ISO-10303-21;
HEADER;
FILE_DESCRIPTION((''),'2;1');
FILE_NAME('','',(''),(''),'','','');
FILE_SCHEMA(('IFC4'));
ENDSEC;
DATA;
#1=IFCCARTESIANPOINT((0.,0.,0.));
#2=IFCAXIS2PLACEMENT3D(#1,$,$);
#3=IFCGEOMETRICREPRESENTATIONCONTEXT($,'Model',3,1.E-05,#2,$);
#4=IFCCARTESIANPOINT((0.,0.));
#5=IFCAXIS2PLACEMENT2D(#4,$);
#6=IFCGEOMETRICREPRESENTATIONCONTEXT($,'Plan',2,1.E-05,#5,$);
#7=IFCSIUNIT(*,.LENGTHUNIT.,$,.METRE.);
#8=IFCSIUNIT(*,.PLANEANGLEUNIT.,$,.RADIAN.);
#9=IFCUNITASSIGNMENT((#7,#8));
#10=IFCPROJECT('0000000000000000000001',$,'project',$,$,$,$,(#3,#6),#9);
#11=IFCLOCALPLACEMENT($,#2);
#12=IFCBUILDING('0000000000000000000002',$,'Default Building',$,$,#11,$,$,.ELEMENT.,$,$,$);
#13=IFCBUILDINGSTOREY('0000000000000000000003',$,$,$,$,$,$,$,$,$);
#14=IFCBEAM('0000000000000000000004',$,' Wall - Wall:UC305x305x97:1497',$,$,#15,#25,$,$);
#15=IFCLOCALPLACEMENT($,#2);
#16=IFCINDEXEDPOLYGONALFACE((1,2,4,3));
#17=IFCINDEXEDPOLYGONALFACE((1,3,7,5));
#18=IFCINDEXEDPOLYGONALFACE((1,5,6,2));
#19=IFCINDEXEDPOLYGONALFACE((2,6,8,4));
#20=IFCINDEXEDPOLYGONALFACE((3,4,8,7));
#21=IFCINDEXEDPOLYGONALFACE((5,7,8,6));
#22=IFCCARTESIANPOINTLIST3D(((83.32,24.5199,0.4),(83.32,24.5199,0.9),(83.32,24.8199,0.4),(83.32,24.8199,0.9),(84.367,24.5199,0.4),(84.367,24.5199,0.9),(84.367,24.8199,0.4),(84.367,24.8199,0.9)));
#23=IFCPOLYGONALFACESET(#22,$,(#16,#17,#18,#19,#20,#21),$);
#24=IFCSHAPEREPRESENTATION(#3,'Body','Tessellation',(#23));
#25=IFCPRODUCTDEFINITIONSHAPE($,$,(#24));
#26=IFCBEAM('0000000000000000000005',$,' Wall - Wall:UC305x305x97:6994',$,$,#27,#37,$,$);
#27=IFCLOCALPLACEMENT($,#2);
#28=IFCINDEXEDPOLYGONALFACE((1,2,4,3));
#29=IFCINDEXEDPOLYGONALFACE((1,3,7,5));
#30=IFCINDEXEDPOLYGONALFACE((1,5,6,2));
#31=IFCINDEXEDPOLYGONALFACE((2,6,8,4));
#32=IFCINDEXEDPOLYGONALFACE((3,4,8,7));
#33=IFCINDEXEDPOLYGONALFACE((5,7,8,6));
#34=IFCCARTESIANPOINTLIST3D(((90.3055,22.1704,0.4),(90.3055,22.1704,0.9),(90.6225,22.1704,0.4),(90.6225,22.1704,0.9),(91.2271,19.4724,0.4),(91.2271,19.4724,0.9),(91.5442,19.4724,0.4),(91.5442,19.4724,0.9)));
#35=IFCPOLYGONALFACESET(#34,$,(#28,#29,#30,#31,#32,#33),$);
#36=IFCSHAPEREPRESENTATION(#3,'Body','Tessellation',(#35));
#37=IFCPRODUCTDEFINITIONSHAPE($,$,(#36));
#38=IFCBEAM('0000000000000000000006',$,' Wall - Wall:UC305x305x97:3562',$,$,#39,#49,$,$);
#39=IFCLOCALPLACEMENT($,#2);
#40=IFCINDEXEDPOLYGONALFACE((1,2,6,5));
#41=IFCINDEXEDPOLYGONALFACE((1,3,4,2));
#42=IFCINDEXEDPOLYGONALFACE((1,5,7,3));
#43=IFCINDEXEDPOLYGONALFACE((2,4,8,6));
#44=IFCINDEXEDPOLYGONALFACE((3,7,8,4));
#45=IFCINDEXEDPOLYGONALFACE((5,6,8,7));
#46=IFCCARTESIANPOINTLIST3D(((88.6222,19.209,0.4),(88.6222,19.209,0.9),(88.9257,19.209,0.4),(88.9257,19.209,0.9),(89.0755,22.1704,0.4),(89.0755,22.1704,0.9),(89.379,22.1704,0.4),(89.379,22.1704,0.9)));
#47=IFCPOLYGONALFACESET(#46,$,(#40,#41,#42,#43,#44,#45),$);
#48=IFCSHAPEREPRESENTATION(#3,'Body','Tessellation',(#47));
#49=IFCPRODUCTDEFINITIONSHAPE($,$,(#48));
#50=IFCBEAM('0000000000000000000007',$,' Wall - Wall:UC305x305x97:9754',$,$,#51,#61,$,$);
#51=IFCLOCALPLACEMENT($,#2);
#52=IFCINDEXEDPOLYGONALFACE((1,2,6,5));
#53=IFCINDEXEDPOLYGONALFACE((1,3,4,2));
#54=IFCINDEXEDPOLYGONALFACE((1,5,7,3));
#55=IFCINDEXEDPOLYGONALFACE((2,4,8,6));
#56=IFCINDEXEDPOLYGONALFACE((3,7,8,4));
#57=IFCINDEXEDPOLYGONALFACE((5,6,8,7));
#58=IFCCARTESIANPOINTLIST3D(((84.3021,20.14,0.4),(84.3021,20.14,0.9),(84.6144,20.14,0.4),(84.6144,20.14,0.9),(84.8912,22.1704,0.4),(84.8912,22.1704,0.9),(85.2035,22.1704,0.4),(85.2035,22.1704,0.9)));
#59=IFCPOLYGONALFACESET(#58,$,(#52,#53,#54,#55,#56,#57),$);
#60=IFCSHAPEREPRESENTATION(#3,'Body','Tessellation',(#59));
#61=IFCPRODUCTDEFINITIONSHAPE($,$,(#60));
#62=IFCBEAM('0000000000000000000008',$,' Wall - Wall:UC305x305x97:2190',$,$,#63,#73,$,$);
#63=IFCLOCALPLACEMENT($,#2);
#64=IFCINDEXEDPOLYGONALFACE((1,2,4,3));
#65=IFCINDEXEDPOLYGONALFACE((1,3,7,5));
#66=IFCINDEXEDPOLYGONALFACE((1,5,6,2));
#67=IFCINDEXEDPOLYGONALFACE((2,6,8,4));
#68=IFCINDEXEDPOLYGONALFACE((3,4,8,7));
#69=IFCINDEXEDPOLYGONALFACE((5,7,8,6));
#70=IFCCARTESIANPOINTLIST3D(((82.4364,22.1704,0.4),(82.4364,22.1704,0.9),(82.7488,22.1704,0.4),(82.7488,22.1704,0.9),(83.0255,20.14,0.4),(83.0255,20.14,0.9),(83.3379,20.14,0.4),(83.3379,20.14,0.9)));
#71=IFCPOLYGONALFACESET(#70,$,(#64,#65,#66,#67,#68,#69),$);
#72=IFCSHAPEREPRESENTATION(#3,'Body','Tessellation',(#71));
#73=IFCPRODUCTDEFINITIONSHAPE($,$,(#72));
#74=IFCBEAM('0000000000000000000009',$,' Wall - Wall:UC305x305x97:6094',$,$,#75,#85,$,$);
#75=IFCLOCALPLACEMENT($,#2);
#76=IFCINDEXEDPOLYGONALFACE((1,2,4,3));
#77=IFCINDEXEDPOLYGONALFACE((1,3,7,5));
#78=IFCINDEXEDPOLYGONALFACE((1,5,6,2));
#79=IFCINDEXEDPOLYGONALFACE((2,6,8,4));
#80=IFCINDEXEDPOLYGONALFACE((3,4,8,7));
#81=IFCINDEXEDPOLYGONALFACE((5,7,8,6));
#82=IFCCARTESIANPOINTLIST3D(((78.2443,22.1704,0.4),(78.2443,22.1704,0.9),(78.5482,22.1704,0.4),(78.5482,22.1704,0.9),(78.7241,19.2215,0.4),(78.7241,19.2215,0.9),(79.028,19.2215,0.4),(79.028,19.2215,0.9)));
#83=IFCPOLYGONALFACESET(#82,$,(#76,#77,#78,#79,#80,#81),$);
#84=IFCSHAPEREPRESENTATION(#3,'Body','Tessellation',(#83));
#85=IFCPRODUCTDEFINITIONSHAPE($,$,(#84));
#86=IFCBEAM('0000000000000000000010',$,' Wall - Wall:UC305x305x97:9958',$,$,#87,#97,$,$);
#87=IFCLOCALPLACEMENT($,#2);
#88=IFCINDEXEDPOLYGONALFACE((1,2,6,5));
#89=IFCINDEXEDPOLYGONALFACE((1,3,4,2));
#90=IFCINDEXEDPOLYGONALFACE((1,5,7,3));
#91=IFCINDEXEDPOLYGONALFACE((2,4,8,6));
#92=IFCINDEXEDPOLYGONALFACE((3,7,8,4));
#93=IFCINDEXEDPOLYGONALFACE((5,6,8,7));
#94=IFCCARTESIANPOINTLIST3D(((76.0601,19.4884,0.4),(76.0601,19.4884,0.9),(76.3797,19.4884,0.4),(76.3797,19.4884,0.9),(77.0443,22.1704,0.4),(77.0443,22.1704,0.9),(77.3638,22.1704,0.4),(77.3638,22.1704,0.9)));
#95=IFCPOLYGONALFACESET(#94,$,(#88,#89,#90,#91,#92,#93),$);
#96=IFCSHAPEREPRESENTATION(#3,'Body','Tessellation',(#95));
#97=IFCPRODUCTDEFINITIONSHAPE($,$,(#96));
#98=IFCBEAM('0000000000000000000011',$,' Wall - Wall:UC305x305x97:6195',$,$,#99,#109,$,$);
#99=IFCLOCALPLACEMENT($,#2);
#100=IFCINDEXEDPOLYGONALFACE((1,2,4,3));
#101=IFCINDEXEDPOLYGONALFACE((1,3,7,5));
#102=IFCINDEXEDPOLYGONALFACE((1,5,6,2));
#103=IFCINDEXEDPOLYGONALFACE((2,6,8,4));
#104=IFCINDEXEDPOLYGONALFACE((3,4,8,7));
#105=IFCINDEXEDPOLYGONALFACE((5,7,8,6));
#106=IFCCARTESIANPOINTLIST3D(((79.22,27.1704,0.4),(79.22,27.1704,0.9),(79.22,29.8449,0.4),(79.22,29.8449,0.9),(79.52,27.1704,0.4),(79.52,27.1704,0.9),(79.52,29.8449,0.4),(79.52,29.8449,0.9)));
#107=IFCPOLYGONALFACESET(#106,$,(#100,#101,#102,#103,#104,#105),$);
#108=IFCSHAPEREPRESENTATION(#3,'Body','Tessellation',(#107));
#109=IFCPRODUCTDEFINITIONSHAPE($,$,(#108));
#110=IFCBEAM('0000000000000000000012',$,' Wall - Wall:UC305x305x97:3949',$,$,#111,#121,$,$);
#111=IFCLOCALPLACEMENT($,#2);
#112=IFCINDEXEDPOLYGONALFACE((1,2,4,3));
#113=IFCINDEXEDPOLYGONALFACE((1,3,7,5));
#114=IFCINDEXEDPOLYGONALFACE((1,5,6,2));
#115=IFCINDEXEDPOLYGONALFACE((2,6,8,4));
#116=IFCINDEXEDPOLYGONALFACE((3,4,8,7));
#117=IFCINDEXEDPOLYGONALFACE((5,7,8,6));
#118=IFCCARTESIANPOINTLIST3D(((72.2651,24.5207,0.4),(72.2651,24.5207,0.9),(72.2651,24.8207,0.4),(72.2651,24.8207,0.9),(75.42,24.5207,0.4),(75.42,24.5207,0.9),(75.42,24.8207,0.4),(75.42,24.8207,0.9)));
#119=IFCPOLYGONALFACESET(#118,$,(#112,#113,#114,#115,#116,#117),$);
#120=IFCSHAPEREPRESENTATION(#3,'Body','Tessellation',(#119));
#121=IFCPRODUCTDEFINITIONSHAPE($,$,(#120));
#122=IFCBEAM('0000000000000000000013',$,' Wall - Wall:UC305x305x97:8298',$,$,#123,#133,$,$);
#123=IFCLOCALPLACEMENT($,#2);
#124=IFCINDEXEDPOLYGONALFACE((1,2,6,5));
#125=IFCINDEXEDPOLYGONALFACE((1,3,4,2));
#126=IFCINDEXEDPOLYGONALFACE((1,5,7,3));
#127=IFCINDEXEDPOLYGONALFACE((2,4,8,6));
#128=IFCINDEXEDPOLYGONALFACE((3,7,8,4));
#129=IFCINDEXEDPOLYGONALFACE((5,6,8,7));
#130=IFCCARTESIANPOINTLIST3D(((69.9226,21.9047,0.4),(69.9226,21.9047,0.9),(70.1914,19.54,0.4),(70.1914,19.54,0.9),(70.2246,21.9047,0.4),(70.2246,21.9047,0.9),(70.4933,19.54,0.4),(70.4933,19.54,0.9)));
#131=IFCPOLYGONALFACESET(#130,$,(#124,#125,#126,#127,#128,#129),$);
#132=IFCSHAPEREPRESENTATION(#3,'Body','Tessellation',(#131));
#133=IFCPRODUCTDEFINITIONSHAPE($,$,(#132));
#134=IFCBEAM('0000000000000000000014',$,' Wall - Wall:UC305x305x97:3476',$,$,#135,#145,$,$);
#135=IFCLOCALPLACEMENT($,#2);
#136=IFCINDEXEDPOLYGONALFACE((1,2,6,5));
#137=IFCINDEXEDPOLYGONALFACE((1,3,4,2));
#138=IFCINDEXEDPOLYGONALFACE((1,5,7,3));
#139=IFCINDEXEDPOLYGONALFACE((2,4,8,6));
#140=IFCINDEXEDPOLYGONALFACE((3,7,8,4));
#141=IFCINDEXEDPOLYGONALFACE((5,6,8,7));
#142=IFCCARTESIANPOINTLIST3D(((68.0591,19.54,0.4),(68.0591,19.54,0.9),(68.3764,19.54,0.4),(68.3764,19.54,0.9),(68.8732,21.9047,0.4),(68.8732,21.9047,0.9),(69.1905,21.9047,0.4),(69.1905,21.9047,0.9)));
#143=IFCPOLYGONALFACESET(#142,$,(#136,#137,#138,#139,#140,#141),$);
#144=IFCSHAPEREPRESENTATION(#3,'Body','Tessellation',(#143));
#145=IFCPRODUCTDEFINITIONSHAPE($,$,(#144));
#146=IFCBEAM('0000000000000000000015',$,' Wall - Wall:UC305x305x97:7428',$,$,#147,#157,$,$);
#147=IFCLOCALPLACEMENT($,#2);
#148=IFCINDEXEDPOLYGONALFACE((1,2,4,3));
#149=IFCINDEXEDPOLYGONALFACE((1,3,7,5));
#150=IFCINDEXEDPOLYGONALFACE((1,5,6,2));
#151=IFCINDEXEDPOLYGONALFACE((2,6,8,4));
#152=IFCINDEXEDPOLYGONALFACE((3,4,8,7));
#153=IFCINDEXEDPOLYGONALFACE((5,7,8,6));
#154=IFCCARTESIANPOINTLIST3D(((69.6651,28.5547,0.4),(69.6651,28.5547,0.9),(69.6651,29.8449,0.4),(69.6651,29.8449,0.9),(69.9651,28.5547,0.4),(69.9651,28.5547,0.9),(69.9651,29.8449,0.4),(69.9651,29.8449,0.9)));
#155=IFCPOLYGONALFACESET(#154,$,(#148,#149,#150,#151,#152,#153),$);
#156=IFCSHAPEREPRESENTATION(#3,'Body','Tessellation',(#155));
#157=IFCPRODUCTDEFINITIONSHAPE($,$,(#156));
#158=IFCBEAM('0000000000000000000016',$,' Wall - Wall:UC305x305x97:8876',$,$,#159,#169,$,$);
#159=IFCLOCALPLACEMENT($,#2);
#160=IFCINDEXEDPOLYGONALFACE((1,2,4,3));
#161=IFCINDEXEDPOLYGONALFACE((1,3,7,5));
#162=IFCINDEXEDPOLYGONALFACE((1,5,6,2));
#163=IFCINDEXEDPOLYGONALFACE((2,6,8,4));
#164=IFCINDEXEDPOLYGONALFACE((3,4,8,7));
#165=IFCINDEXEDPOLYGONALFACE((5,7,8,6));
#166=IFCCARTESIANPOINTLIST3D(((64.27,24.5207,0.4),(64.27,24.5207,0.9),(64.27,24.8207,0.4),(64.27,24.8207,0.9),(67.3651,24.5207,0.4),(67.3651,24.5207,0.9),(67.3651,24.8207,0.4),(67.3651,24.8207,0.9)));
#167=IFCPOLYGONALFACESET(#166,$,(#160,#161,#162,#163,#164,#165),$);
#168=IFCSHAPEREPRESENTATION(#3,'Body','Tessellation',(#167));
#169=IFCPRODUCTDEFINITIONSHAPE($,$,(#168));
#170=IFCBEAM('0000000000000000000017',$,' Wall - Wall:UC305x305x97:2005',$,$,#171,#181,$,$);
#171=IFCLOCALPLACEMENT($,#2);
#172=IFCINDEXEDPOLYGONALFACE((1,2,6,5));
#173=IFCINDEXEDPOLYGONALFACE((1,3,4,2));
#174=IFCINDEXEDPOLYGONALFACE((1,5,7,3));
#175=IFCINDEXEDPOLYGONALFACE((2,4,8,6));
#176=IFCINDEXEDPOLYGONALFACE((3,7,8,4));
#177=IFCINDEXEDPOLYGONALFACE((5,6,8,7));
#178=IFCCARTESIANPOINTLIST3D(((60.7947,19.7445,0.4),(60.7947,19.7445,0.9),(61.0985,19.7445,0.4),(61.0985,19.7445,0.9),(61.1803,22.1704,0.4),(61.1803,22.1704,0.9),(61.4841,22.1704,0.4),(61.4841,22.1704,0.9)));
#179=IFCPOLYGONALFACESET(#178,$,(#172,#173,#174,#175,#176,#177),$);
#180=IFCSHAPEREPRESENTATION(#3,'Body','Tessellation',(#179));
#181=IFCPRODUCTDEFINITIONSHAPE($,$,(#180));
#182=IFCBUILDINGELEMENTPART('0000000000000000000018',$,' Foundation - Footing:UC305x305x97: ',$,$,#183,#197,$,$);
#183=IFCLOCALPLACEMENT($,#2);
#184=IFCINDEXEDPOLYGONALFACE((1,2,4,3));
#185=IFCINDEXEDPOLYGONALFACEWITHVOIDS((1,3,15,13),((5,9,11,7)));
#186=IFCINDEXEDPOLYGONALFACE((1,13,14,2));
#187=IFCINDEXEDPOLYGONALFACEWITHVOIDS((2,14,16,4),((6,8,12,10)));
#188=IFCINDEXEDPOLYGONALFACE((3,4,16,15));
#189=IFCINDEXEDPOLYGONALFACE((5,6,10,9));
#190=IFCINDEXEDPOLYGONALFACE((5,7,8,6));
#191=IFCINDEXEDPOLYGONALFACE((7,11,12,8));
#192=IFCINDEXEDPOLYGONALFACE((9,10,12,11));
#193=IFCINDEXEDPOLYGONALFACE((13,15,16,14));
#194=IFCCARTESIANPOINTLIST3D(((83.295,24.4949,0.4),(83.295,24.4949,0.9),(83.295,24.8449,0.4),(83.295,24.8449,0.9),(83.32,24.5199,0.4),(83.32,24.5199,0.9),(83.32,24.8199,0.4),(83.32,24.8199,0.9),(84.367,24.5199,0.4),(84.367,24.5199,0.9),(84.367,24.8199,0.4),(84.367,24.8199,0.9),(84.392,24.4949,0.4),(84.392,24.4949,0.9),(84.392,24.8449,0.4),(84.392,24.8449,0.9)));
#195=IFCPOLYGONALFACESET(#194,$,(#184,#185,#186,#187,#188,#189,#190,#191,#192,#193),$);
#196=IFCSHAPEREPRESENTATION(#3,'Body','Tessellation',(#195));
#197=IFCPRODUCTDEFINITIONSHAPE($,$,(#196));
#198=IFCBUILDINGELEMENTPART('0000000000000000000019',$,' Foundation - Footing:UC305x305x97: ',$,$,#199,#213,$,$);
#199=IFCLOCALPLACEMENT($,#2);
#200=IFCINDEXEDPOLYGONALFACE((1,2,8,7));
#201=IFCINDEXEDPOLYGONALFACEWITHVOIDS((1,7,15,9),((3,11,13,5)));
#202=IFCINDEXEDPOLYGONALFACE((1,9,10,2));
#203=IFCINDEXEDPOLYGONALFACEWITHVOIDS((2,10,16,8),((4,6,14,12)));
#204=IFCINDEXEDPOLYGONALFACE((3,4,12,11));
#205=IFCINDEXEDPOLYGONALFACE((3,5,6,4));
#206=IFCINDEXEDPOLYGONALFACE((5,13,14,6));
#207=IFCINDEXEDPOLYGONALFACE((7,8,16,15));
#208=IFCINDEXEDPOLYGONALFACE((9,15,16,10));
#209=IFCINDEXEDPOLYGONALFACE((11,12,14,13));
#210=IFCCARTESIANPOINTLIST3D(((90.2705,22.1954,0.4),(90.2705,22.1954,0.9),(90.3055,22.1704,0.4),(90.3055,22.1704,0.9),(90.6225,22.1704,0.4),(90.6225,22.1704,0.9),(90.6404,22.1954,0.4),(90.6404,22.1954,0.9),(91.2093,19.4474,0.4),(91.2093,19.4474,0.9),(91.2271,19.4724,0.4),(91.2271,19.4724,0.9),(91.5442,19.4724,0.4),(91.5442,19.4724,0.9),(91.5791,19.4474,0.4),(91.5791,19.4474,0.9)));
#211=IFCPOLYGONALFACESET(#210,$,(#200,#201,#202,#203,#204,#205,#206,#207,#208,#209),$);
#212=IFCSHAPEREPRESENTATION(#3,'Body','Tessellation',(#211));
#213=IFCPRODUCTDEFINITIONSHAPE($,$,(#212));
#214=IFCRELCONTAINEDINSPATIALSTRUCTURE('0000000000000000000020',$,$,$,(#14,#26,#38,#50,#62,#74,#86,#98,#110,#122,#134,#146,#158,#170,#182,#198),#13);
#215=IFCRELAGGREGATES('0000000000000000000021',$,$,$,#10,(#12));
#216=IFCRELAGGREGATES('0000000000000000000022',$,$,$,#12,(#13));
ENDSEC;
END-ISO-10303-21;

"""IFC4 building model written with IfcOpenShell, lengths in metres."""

from ifc_helpers import new_model, si_unit, origin, origin_2d, place, context, project, spatial, polyline, outline, extrude, element, save


model = new_model("IFC4")

# Units and contexts
model_context = context("Model", 3, precision=1e-05, world=origin())
plan_context = context("Plan", 2, precision=1e-05, world=origin_2d())
ifc_project = project(units=[si_unit("LENGTHUNIT", "METRE"), si_unit("PLANEANGLEUNIT", "RADIAN")], contexts=[model_context, plan_context])

# Building, storey
building_placement = place(None, origin())
building = spatial("IfcBuilding", under=ifc_project, at=building_placement, Name="Default Building", CompositionType="ELEMENT")
storey = spatial("IfcBuildingStorey", under=building)

# Beams
element("IfcBeam", 1, inside=storey, Name=" Wall - Wall:UC305x305x97:1497", context=model_context, shape_type="SweptSolid", body=[
    extrude(outline(polyline([(84.367, 24.5199, 0.4), (84.367, 24.8199, 0.4), (83.32, 24.8199, 0.4), (83.32, 24.5199, 0.4), (84.367, 24.5199, 0.4)])), None, (0.0, 0.0, 1.0), 0.5),
])
element("IfcBeam", 2, inside=storey, Name=" Wall - Wall:UC305x305x97:6994", context=model_context, shape_type="SweptSolid", body=[
    extrude(outline(polyline([(91.5442, 19.4724, 0.4), (91.2271, 19.4724, 0.4), (90.3055, 22.1704, 0.4), (90.6225, 22.1704, 0.4), (91.5442, 19.4724, 0.4)])), None, (0.0, 0.0, 1.0), 0.5),
])
element("IfcBeam", 3, inside=storey, Name=" Wall - Wall:UC305x305x97:3562", context=model_context, shape_type="SweptSolid", body=[
    extrude(outline(polyline([(88.9257, 19.209, 0.4), (88.6222, 19.209, 0.4), (89.0755, 22.1704, 0.4), (89.379, 22.1704, 0.4), (88.9257, 19.209, 0.4)])), None, (0.0, 0.0, 1.0), 0.5),
])
element("IfcBeam", 4, inside=storey, Name=" Wall - Wall:UC305x305x97:9754", context=model_context, shape_type="SweptSolid", body=[
    extrude(outline(polyline([(84.6144, 20.14, 0.4), (84.3021, 20.14, 0.4), (84.8912, 22.1704, 0.4), (85.2035, 22.1704, 0.4), (84.6144, 20.14, 0.4)])), None, (0.0, 0.0, 1.0), 0.5),
])
element("IfcBeam", 5, inside=storey, Name=" Wall - Wall:UC305x305x97:2190", context=model_context, shape_type="SweptSolid", body=[
    extrude(outline(polyline([(83.3379, 20.14, 0.4), (82.7488, 22.1704, 0.4), (82.4364, 22.1704, 0.4), (83.0255, 20.14, 0.4), (83.3379, 20.14, 0.4)])), None, (0.0, 0.0, 1.0), 0.5),
])
element("IfcBeam", 6, inside=storey, Name=" Wall - Wall:UC305x305x97:6094", context=model_context, shape_type="SweptSolid", body=[
    extrude(outline(polyline([(79.028, 19.2215, 0.4), (78.7241, 19.2215, 0.4), (78.2443, 22.1704, 0.4), (78.5482, 22.1704, 0.4), (79.028, 19.2215, 0.4)])), None, (0.0, 0.0, 1.0), 0.5),
])
element("IfcBeam", 7, inside=storey, Name=" Wall - Wall:UC305x305x97:9958", context=model_context, shape_type="SweptSolid", body=[
    extrude(outline(polyline([(76.3797, 19.4884, 0.4), (76.0601, 19.4884, 0.4), (77.0443, 22.1704, 0.4), (77.3638, 22.1704, 0.4), (76.3797, 19.4884, 0.4)])), None, (0.0, 0.0, 1.0), 0.5),
])
element("IfcBeam", 8, inside=storey, Name=" Wall - Wall:UC305x305x97:6195", context=model_context, shape_type="SweptSolid", body=[
    extrude(outline(polyline([(79.52, 27.1704, 0.4), (79.22, 27.1704, 0.4), (79.22, 29.8449, 0.4), (79.52, 29.8449, 0.4), (79.52, 27.1704, 0.4)])), None, (0.0, 0.0, 1.0), 0.5),
])
element("IfcBeam", 9, inside=storey, Name=" Wall - Wall:UC305x305x97:3949", context=model_context, shape_type="SweptSolid", body=[
    extrude(outline(polyline([(75.42, 24.5207, 0.4), (75.42, 24.8207, 0.4), (72.2651, 24.8207, 0.4), (72.2651, 24.5207, 0.4), (75.42, 24.5207, 0.4)])), None, (0.0, 0.0, 1.0), 0.5),
])
element("IfcBeam", 10, inside=storey, Name=" Wall - Wall:UC305x305x97:8298", context=model_context, shape_type="SweptSolid", body=[
    extrude(outline(polyline([(70.4933, 19.54, 0.4), (70.1914, 19.54, 0.4), (69.9226, 21.9047, 0.4), (70.2246, 21.9047, 0.4), (70.4933, 19.54, 0.4)])), None, (0.0, 0.0, 1.0), 0.5),
])
element("IfcBeam", 11, inside=storey, Name=" Wall - Wall:UC305x305x97:3476", context=model_context, shape_type="SweptSolid", body=[
    extrude(outline(polyline([(68.3764, 19.54, 0.4), (68.0591, 19.54, 0.4), (68.8732, 21.9047, 0.4), (69.1905, 21.9047, 0.4), (68.3764, 19.54, 0.4)])), None, (0.0, 0.0, 1.0), 0.5),
])
element("IfcBeam", 12, inside=storey, Name=" Wall - Wall:UC305x305x97:7428", context=model_context, shape_type="SweptSolid", body=[
    extrude(outline(polyline([(69.9651, 28.5547, 0.4), (69.6651, 28.5547, 0.4), (69.6651, 29.8449, 0.4), (69.9651, 29.8449, 0.4), (69.9651, 28.5547, 0.4)])), None, (0.0, 0.0, 1.0), 0.5),
])
element("IfcBeam", 13, inside=storey, Name=" Wall - Wall:UC305x305x97:8876", context=model_context, shape_type="SweptSolid", body=[
    extrude(outline(polyline([(67.3651, 24.5207, 0.4), (67.3651, 24.8207, 0.4), (64.27, 24.8207, 0.4), (64.27, 24.5207, 0.4), (67.3651, 24.5207, 0.4)])), None, (0.0, 0.0, 1.0), 0.5),
])
element("IfcBeam", 14, inside=storey, Name=" Wall - Wall:UC305x305x97:2005", context=model_context, shape_type="SweptSolid", body=[
    extrude(outline(polyline([(61.0985, 19.7445, 0.4), (60.7947, 19.7445, 0.4), (61.1803, 22.1704, 0.4), (61.4841, 22.1704, 0.4), (61.0985, 19.7445, 0.4)])), None, (0.0, 0.0, 1.0), 0.5),
])

# Building element parts, openings
building_element_part_1 = element("IfcBuildingElementPart", 15, inside=storey, Name=" Foundation - Footing:UC305x305x97: ", context=model_context, shape_type="SweptSolid", body=[
    extrude(outline(polyline([(84.392, 24.4949, 0.4), (84.392, 24.8449, 0.4), (83.295, 24.8449, 0.4), (83.295, 24.4949, 0.4), (84.392, 24.4949, 0.4)])), None, (0.0, 0.0, 1.0), 0.5),
])
element("IfcOpeningElement", 16, inside=storey, cuts=building_element_part_1, context=model_context, shape_type="SweptSolid", body=[
    extrude(outline(polyline([(84.367, 24.5199, 0.4), (84.367, 24.8199, 0.4), (83.32, 24.8199, 0.4), (83.32, 24.5199, 0.4), (84.367, 24.5199, 0.4)])), None, (0.0, 0.0, 1.0), 0.5),
])
building_element_part_2 = element("IfcBuildingElementPart", 17, inside=storey, Name=" Foundation - Footing:UC305x305x97: ", context=model_context, shape_type="SweptSolid", body=[
    extrude(outline(polyline([(91.5791, 19.4474, 0.4), (91.2093, 19.4474, 0.4), (90.2705, 22.1954, 0.4), (90.6404, 22.1954, 0.4), (91.5791, 19.4474, 0.4)])), None, (0.0, 0.0, 1.0), 0.5),
])
element("IfcOpeningElement", 18, inside=storey, cuts=building_element_part_2, context=model_context, shape_type="SweptSolid", body=[
    extrude(outline(polyline([(91.5442, 19.4724, 0.4), (91.2271, 19.4724, 0.4), (90.3055, 22.1704, 0.4), (90.6225, 22.1704, 0.4), (91.5442, 19.4724, 0.4)])), None, (0.0, 0.0, 1.0), 0.5),
])

save(model, "model.ifc")
